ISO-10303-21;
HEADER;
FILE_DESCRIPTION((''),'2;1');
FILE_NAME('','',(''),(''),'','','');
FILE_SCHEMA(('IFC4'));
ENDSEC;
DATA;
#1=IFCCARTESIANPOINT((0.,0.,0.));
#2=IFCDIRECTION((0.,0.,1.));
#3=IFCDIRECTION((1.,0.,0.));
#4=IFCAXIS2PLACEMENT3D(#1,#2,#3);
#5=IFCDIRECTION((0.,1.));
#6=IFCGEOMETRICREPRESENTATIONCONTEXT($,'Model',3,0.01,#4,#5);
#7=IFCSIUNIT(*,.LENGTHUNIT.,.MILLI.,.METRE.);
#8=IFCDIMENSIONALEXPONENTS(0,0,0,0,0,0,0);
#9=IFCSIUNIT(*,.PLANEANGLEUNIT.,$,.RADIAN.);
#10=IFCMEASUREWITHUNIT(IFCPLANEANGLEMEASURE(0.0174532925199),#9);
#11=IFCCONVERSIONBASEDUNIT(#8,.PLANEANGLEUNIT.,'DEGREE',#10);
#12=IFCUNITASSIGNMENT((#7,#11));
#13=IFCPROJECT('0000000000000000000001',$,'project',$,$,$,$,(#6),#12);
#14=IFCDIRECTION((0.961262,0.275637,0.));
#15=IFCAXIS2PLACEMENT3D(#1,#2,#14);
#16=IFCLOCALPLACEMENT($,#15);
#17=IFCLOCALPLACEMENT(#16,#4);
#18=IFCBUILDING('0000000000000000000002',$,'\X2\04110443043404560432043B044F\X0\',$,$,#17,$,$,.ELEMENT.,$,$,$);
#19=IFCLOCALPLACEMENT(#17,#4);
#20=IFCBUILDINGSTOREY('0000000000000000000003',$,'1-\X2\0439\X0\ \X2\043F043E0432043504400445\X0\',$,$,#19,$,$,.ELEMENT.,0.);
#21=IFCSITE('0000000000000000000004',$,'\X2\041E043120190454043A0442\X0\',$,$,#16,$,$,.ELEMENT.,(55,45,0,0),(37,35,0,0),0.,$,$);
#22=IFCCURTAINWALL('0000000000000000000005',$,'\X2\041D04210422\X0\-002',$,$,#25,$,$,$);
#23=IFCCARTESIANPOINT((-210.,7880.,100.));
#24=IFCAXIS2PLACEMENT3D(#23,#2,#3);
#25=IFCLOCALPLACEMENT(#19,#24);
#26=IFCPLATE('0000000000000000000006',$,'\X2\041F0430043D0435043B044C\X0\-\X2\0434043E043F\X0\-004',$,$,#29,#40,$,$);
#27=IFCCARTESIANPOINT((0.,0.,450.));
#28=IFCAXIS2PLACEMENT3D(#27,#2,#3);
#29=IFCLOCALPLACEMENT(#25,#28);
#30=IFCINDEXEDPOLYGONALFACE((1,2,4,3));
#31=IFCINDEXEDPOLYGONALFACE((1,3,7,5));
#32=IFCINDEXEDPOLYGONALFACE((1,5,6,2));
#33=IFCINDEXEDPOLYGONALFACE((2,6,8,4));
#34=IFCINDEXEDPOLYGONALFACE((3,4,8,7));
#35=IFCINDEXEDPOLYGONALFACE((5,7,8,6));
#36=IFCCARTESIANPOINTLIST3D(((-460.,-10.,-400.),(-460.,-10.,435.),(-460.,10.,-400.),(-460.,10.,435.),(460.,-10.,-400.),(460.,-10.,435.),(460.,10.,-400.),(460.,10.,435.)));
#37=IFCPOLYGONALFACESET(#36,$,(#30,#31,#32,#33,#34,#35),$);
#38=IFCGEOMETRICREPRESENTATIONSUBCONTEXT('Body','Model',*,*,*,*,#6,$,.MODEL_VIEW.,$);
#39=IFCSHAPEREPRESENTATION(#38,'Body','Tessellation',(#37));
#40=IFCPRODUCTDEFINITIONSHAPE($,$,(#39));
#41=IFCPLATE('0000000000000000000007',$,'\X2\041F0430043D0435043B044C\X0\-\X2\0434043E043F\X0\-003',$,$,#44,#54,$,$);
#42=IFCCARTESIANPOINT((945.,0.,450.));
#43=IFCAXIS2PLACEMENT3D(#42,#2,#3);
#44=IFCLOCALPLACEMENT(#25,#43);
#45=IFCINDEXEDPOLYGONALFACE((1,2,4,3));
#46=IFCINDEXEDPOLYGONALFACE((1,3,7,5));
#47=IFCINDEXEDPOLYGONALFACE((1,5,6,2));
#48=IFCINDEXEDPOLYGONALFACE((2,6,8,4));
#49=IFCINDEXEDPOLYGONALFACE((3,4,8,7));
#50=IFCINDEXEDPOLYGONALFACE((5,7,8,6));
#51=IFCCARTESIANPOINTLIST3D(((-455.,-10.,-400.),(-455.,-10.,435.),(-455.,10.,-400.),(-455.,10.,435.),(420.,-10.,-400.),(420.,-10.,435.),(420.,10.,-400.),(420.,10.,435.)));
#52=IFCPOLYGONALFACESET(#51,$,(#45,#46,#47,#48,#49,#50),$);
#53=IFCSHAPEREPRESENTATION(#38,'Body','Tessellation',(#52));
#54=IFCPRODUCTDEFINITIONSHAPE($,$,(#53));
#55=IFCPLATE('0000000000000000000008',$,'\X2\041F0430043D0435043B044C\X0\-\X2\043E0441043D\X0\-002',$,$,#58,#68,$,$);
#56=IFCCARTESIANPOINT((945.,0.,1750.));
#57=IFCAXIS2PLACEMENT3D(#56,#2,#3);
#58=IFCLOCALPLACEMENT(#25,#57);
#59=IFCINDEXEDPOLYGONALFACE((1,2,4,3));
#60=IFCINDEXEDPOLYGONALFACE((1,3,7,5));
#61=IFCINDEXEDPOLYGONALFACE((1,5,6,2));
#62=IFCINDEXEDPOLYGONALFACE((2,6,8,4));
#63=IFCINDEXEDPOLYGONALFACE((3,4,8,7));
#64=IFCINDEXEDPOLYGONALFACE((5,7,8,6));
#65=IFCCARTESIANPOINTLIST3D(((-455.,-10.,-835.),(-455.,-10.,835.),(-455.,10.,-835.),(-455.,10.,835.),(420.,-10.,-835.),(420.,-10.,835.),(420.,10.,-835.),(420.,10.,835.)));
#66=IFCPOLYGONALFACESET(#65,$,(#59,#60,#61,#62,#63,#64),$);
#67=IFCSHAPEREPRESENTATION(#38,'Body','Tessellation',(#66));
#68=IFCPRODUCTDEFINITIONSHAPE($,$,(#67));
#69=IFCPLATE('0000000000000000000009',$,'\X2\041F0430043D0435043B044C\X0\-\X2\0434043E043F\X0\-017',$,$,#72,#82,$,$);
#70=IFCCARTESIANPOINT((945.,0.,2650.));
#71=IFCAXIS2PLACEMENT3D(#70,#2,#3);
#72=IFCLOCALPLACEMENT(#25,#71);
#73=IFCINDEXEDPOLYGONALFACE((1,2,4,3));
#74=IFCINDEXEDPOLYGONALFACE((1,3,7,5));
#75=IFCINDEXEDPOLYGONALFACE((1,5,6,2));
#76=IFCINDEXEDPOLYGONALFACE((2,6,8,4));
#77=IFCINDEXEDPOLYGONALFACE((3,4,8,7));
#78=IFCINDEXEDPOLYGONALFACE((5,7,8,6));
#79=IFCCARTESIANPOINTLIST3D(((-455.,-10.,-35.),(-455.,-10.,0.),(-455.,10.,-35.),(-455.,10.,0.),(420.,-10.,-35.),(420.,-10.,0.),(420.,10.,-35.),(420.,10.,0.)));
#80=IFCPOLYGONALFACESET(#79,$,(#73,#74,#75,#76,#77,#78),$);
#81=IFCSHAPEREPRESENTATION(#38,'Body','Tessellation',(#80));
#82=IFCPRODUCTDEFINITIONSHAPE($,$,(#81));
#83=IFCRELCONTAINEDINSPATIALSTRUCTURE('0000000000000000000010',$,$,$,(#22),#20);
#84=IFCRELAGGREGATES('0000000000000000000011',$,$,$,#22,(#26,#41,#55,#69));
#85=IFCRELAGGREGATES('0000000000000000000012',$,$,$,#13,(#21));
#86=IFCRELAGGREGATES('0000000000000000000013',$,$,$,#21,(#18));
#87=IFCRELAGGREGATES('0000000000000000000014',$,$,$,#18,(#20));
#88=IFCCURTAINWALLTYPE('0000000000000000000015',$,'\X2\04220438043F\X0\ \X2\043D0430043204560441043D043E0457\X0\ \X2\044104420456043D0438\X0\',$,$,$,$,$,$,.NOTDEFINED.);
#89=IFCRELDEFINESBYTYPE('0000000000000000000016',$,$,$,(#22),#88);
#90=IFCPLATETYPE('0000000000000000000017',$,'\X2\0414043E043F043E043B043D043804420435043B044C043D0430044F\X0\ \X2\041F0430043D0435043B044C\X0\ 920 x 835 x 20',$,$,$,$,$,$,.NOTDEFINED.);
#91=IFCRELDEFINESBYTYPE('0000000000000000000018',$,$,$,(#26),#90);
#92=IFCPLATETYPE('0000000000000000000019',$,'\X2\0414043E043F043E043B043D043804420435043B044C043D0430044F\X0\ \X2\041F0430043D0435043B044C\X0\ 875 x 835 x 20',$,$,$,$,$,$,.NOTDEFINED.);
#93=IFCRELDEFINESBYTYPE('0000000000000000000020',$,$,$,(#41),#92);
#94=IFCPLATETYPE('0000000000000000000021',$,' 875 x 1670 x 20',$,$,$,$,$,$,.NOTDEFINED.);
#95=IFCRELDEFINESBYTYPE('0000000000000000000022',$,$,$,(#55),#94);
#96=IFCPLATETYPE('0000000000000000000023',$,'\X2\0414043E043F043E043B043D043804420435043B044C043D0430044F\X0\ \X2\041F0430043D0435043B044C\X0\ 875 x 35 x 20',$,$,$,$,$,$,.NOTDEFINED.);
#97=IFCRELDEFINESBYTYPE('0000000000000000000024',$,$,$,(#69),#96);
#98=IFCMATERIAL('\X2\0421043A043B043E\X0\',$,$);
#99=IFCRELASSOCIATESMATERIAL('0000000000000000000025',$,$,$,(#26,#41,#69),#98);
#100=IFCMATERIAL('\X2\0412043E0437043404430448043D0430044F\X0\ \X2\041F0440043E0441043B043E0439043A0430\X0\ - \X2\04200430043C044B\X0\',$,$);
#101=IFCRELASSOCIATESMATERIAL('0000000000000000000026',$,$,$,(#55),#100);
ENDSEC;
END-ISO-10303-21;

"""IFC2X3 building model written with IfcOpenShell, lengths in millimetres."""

from ifc_helpers import new_model, entity, si_unit, converted_unit, direction, frame, origin_with_axes, place, context, subcontext, project, spatial, polyline, outline, extrude, material, type_object, element, aggregate, save


model = new_model("IFC2X3")

# Units and contexts
model_context = context("Model", 3, precision=0.01, world=origin_with_axes(), true_north=direction((0.0, 1.0)))
body_context = subcontext(model_context, "Body", "Model", "MODEL_VIEW")
ifc_project = project(units=[si_unit("LENGTHUNIT", "METRE", prefix="MILLI"), converted_unit("PLANEANGLEUNIT", "DEGREE", entity("IfcPlaneAngleMeasure", 0.0174532925199), si_unit("PLANEANGLEUNIT", "RADIAN"), dimensions=[0, 0, 0, 0, 0, 0, 0])], contexts=[model_context])

# Site, building, storey
site_placement = place(None, frame((0.0, 0.0, 0.0), z_axis=(0.0, 0.0, 1.0), x_axis=(0.961262, 0.275637, 0.0)))
site = spatial("IfcSite", under=ifc_project, at=site_placement, Name="Об’єкт", CompositionType="ELEMENT", RefLatitude=(55, 45, 0, 0), RefLongitude=(37, 35, 0, 0), RefElevation=0.0)
building_placement = place(site_placement, origin_with_axes())
building = spatial("IfcBuilding", under=site, at=building_placement, Name="Будівля", CompositionType="ELEMENT")
storey_placement = place(building_placement, origin_with_axes())
storey = spatial("IfcBuildingStorey", under=building, at=storey_placement, Name="1-й поверх", CompositionType="ELEMENT", Elevation=0.0)

# Curtain wall
curtain_wall_type = type_object("IfcCurtainWallType", Name="Тип навісної стіни", PredefinedType="NOTDEFINED")
curtain_wall_placement = place(storey_placement, frame((-210.0, 7880.0, 100.0), z_axis=(0.0, 0.0, 1.0), x_axis=(1.0, 0.0, 0.0)))
curtain_wall = element("IfcCurtainWall", 1, at=curtain_wall_placement, inside=storey, type_object=curtain_wall_type, Name="НСТ-002")
ifc_material_1 = material(Name="Воздушная Прослойка - Рамы")

# Plates
ifc_material_2 = material(Name="Скло")
plate_type_1 = type_object("IfcPlateType", Name="Дополнительная Панель 920 x 835 x 20", PredefinedType="NOTDEFINED")
plate_1_placement = place(curtain_wall_placement, frame((0.0, 0.0, 450.0), z_axis=(0.0, 0.0, 1.0), x_axis=(1.0, 0.0, 0.0)))
plate_1 = element("IfcPlate", 2, at=plate_1_placement, type_object=plate_type_1, material=ifc_material_2, Name="Панель-доп-004", context=body_context, shape_type="SweptSolid", body=[
    extrude(outline(polyline([(-460.0, -435.0), (460.0, -435.0), (460.0, 400.0), (-460.0, 400.0), (-460.0, -435.0)])), frame((0.0, -10.0, 0.0), z_axis=(0.0, 1.0, 0.0), x_axis=(1.0, 0.0, 0.0)), (0.0, 0.0, 1.0), 20.0),
])
plate_type_2 = type_object("IfcPlateType", Name="Дополнительная Панель 875 x 835 x 20", PredefinedType="NOTDEFINED")
plate_2_placement = place(curtain_wall_placement, frame((945.0, 0.0, 450.0), z_axis=(0.0, 0.0, 1.0), x_axis=(1.0, 0.0, 0.0)))
plate_2 = element("IfcPlate", 3, at=plate_2_placement, type_object=plate_type_2, material=ifc_material_2, Name="Панель-доп-003", context=body_context, shape_type="SweptSolid", body=[
    extrude(outline(polyline([(-455.0, -435.0), (420.0, -435.0), (420.0, 400.0), (-455.0, 400.0), (-455.0, -435.0)])), frame((0.0, -10.0, 0.0), z_axis=(0.0, 1.0, 0.0), x_axis=(1.0, 0.0, 0.0)), (0.0, 0.0, 1.0), 20.0),
])
plate_type_3 = type_object("IfcPlateType", Name=" 875 x 1670 x 20", PredefinedType="NOTDEFINED")
plate_3_placement = place(curtain_wall_placement, frame((945.0, 0.0, 1750.0), z_axis=(0.0, 0.0, 1.0), x_axis=(1.0, 0.0, 0.0)))
plate_3 = element("IfcPlate", 4, at=plate_3_placement, type_object=plate_type_3, material=ifc_material_1, Name="Панель-осн-002", context=body_context, shape_type="SweptSolid", body=[
    extrude(outline(polyline([(-455.0, -835.0), (420.0, -835.0), (420.0, 835.0), (-455.0, 835.0), (-455.0, -835.0)])), frame((0.0, -10.0, 0.0), z_axis=(0.0, 1.0, 0.0), x_axis=(1.0, 0.0, 0.0)), (0.0, 0.0, 1.0), 20.0),
])
plate_type_4 = type_object("IfcPlateType", Name="Дополнительная Панель 875 x 35 x 20", PredefinedType="NOTDEFINED")
plate_4_placement = place(curtain_wall_placement, frame((945.0, 0.0, 2650.0), z_axis=(0.0, 0.0, 1.0), x_axis=(1.0, 0.0, 0.0)))
plate_4 = element("IfcPlate", 5, at=plate_4_placement, type_object=plate_type_4, material=ifc_material_2, Name="Панель-доп-017", context=body_context, shape_type="SweptSolid", body=[
    extrude(outline(polyline([(-455.0, 0.0), (420.0, 0.0), (420.0, 35.0), (-455.0, 35.0), (-455.0, 0.0)])), frame((0.0, -10.0, 0.0), z_axis=(0.0, 1.0, 0.0), x_axis=(1.0, 0.0, 0.0)), (0.0, 0.0, 1.0), 20.0),
])
aggregate(curtain_wall, [plate_1, plate_2, plate_3, plate_4])

save(model, "model.ifc")
